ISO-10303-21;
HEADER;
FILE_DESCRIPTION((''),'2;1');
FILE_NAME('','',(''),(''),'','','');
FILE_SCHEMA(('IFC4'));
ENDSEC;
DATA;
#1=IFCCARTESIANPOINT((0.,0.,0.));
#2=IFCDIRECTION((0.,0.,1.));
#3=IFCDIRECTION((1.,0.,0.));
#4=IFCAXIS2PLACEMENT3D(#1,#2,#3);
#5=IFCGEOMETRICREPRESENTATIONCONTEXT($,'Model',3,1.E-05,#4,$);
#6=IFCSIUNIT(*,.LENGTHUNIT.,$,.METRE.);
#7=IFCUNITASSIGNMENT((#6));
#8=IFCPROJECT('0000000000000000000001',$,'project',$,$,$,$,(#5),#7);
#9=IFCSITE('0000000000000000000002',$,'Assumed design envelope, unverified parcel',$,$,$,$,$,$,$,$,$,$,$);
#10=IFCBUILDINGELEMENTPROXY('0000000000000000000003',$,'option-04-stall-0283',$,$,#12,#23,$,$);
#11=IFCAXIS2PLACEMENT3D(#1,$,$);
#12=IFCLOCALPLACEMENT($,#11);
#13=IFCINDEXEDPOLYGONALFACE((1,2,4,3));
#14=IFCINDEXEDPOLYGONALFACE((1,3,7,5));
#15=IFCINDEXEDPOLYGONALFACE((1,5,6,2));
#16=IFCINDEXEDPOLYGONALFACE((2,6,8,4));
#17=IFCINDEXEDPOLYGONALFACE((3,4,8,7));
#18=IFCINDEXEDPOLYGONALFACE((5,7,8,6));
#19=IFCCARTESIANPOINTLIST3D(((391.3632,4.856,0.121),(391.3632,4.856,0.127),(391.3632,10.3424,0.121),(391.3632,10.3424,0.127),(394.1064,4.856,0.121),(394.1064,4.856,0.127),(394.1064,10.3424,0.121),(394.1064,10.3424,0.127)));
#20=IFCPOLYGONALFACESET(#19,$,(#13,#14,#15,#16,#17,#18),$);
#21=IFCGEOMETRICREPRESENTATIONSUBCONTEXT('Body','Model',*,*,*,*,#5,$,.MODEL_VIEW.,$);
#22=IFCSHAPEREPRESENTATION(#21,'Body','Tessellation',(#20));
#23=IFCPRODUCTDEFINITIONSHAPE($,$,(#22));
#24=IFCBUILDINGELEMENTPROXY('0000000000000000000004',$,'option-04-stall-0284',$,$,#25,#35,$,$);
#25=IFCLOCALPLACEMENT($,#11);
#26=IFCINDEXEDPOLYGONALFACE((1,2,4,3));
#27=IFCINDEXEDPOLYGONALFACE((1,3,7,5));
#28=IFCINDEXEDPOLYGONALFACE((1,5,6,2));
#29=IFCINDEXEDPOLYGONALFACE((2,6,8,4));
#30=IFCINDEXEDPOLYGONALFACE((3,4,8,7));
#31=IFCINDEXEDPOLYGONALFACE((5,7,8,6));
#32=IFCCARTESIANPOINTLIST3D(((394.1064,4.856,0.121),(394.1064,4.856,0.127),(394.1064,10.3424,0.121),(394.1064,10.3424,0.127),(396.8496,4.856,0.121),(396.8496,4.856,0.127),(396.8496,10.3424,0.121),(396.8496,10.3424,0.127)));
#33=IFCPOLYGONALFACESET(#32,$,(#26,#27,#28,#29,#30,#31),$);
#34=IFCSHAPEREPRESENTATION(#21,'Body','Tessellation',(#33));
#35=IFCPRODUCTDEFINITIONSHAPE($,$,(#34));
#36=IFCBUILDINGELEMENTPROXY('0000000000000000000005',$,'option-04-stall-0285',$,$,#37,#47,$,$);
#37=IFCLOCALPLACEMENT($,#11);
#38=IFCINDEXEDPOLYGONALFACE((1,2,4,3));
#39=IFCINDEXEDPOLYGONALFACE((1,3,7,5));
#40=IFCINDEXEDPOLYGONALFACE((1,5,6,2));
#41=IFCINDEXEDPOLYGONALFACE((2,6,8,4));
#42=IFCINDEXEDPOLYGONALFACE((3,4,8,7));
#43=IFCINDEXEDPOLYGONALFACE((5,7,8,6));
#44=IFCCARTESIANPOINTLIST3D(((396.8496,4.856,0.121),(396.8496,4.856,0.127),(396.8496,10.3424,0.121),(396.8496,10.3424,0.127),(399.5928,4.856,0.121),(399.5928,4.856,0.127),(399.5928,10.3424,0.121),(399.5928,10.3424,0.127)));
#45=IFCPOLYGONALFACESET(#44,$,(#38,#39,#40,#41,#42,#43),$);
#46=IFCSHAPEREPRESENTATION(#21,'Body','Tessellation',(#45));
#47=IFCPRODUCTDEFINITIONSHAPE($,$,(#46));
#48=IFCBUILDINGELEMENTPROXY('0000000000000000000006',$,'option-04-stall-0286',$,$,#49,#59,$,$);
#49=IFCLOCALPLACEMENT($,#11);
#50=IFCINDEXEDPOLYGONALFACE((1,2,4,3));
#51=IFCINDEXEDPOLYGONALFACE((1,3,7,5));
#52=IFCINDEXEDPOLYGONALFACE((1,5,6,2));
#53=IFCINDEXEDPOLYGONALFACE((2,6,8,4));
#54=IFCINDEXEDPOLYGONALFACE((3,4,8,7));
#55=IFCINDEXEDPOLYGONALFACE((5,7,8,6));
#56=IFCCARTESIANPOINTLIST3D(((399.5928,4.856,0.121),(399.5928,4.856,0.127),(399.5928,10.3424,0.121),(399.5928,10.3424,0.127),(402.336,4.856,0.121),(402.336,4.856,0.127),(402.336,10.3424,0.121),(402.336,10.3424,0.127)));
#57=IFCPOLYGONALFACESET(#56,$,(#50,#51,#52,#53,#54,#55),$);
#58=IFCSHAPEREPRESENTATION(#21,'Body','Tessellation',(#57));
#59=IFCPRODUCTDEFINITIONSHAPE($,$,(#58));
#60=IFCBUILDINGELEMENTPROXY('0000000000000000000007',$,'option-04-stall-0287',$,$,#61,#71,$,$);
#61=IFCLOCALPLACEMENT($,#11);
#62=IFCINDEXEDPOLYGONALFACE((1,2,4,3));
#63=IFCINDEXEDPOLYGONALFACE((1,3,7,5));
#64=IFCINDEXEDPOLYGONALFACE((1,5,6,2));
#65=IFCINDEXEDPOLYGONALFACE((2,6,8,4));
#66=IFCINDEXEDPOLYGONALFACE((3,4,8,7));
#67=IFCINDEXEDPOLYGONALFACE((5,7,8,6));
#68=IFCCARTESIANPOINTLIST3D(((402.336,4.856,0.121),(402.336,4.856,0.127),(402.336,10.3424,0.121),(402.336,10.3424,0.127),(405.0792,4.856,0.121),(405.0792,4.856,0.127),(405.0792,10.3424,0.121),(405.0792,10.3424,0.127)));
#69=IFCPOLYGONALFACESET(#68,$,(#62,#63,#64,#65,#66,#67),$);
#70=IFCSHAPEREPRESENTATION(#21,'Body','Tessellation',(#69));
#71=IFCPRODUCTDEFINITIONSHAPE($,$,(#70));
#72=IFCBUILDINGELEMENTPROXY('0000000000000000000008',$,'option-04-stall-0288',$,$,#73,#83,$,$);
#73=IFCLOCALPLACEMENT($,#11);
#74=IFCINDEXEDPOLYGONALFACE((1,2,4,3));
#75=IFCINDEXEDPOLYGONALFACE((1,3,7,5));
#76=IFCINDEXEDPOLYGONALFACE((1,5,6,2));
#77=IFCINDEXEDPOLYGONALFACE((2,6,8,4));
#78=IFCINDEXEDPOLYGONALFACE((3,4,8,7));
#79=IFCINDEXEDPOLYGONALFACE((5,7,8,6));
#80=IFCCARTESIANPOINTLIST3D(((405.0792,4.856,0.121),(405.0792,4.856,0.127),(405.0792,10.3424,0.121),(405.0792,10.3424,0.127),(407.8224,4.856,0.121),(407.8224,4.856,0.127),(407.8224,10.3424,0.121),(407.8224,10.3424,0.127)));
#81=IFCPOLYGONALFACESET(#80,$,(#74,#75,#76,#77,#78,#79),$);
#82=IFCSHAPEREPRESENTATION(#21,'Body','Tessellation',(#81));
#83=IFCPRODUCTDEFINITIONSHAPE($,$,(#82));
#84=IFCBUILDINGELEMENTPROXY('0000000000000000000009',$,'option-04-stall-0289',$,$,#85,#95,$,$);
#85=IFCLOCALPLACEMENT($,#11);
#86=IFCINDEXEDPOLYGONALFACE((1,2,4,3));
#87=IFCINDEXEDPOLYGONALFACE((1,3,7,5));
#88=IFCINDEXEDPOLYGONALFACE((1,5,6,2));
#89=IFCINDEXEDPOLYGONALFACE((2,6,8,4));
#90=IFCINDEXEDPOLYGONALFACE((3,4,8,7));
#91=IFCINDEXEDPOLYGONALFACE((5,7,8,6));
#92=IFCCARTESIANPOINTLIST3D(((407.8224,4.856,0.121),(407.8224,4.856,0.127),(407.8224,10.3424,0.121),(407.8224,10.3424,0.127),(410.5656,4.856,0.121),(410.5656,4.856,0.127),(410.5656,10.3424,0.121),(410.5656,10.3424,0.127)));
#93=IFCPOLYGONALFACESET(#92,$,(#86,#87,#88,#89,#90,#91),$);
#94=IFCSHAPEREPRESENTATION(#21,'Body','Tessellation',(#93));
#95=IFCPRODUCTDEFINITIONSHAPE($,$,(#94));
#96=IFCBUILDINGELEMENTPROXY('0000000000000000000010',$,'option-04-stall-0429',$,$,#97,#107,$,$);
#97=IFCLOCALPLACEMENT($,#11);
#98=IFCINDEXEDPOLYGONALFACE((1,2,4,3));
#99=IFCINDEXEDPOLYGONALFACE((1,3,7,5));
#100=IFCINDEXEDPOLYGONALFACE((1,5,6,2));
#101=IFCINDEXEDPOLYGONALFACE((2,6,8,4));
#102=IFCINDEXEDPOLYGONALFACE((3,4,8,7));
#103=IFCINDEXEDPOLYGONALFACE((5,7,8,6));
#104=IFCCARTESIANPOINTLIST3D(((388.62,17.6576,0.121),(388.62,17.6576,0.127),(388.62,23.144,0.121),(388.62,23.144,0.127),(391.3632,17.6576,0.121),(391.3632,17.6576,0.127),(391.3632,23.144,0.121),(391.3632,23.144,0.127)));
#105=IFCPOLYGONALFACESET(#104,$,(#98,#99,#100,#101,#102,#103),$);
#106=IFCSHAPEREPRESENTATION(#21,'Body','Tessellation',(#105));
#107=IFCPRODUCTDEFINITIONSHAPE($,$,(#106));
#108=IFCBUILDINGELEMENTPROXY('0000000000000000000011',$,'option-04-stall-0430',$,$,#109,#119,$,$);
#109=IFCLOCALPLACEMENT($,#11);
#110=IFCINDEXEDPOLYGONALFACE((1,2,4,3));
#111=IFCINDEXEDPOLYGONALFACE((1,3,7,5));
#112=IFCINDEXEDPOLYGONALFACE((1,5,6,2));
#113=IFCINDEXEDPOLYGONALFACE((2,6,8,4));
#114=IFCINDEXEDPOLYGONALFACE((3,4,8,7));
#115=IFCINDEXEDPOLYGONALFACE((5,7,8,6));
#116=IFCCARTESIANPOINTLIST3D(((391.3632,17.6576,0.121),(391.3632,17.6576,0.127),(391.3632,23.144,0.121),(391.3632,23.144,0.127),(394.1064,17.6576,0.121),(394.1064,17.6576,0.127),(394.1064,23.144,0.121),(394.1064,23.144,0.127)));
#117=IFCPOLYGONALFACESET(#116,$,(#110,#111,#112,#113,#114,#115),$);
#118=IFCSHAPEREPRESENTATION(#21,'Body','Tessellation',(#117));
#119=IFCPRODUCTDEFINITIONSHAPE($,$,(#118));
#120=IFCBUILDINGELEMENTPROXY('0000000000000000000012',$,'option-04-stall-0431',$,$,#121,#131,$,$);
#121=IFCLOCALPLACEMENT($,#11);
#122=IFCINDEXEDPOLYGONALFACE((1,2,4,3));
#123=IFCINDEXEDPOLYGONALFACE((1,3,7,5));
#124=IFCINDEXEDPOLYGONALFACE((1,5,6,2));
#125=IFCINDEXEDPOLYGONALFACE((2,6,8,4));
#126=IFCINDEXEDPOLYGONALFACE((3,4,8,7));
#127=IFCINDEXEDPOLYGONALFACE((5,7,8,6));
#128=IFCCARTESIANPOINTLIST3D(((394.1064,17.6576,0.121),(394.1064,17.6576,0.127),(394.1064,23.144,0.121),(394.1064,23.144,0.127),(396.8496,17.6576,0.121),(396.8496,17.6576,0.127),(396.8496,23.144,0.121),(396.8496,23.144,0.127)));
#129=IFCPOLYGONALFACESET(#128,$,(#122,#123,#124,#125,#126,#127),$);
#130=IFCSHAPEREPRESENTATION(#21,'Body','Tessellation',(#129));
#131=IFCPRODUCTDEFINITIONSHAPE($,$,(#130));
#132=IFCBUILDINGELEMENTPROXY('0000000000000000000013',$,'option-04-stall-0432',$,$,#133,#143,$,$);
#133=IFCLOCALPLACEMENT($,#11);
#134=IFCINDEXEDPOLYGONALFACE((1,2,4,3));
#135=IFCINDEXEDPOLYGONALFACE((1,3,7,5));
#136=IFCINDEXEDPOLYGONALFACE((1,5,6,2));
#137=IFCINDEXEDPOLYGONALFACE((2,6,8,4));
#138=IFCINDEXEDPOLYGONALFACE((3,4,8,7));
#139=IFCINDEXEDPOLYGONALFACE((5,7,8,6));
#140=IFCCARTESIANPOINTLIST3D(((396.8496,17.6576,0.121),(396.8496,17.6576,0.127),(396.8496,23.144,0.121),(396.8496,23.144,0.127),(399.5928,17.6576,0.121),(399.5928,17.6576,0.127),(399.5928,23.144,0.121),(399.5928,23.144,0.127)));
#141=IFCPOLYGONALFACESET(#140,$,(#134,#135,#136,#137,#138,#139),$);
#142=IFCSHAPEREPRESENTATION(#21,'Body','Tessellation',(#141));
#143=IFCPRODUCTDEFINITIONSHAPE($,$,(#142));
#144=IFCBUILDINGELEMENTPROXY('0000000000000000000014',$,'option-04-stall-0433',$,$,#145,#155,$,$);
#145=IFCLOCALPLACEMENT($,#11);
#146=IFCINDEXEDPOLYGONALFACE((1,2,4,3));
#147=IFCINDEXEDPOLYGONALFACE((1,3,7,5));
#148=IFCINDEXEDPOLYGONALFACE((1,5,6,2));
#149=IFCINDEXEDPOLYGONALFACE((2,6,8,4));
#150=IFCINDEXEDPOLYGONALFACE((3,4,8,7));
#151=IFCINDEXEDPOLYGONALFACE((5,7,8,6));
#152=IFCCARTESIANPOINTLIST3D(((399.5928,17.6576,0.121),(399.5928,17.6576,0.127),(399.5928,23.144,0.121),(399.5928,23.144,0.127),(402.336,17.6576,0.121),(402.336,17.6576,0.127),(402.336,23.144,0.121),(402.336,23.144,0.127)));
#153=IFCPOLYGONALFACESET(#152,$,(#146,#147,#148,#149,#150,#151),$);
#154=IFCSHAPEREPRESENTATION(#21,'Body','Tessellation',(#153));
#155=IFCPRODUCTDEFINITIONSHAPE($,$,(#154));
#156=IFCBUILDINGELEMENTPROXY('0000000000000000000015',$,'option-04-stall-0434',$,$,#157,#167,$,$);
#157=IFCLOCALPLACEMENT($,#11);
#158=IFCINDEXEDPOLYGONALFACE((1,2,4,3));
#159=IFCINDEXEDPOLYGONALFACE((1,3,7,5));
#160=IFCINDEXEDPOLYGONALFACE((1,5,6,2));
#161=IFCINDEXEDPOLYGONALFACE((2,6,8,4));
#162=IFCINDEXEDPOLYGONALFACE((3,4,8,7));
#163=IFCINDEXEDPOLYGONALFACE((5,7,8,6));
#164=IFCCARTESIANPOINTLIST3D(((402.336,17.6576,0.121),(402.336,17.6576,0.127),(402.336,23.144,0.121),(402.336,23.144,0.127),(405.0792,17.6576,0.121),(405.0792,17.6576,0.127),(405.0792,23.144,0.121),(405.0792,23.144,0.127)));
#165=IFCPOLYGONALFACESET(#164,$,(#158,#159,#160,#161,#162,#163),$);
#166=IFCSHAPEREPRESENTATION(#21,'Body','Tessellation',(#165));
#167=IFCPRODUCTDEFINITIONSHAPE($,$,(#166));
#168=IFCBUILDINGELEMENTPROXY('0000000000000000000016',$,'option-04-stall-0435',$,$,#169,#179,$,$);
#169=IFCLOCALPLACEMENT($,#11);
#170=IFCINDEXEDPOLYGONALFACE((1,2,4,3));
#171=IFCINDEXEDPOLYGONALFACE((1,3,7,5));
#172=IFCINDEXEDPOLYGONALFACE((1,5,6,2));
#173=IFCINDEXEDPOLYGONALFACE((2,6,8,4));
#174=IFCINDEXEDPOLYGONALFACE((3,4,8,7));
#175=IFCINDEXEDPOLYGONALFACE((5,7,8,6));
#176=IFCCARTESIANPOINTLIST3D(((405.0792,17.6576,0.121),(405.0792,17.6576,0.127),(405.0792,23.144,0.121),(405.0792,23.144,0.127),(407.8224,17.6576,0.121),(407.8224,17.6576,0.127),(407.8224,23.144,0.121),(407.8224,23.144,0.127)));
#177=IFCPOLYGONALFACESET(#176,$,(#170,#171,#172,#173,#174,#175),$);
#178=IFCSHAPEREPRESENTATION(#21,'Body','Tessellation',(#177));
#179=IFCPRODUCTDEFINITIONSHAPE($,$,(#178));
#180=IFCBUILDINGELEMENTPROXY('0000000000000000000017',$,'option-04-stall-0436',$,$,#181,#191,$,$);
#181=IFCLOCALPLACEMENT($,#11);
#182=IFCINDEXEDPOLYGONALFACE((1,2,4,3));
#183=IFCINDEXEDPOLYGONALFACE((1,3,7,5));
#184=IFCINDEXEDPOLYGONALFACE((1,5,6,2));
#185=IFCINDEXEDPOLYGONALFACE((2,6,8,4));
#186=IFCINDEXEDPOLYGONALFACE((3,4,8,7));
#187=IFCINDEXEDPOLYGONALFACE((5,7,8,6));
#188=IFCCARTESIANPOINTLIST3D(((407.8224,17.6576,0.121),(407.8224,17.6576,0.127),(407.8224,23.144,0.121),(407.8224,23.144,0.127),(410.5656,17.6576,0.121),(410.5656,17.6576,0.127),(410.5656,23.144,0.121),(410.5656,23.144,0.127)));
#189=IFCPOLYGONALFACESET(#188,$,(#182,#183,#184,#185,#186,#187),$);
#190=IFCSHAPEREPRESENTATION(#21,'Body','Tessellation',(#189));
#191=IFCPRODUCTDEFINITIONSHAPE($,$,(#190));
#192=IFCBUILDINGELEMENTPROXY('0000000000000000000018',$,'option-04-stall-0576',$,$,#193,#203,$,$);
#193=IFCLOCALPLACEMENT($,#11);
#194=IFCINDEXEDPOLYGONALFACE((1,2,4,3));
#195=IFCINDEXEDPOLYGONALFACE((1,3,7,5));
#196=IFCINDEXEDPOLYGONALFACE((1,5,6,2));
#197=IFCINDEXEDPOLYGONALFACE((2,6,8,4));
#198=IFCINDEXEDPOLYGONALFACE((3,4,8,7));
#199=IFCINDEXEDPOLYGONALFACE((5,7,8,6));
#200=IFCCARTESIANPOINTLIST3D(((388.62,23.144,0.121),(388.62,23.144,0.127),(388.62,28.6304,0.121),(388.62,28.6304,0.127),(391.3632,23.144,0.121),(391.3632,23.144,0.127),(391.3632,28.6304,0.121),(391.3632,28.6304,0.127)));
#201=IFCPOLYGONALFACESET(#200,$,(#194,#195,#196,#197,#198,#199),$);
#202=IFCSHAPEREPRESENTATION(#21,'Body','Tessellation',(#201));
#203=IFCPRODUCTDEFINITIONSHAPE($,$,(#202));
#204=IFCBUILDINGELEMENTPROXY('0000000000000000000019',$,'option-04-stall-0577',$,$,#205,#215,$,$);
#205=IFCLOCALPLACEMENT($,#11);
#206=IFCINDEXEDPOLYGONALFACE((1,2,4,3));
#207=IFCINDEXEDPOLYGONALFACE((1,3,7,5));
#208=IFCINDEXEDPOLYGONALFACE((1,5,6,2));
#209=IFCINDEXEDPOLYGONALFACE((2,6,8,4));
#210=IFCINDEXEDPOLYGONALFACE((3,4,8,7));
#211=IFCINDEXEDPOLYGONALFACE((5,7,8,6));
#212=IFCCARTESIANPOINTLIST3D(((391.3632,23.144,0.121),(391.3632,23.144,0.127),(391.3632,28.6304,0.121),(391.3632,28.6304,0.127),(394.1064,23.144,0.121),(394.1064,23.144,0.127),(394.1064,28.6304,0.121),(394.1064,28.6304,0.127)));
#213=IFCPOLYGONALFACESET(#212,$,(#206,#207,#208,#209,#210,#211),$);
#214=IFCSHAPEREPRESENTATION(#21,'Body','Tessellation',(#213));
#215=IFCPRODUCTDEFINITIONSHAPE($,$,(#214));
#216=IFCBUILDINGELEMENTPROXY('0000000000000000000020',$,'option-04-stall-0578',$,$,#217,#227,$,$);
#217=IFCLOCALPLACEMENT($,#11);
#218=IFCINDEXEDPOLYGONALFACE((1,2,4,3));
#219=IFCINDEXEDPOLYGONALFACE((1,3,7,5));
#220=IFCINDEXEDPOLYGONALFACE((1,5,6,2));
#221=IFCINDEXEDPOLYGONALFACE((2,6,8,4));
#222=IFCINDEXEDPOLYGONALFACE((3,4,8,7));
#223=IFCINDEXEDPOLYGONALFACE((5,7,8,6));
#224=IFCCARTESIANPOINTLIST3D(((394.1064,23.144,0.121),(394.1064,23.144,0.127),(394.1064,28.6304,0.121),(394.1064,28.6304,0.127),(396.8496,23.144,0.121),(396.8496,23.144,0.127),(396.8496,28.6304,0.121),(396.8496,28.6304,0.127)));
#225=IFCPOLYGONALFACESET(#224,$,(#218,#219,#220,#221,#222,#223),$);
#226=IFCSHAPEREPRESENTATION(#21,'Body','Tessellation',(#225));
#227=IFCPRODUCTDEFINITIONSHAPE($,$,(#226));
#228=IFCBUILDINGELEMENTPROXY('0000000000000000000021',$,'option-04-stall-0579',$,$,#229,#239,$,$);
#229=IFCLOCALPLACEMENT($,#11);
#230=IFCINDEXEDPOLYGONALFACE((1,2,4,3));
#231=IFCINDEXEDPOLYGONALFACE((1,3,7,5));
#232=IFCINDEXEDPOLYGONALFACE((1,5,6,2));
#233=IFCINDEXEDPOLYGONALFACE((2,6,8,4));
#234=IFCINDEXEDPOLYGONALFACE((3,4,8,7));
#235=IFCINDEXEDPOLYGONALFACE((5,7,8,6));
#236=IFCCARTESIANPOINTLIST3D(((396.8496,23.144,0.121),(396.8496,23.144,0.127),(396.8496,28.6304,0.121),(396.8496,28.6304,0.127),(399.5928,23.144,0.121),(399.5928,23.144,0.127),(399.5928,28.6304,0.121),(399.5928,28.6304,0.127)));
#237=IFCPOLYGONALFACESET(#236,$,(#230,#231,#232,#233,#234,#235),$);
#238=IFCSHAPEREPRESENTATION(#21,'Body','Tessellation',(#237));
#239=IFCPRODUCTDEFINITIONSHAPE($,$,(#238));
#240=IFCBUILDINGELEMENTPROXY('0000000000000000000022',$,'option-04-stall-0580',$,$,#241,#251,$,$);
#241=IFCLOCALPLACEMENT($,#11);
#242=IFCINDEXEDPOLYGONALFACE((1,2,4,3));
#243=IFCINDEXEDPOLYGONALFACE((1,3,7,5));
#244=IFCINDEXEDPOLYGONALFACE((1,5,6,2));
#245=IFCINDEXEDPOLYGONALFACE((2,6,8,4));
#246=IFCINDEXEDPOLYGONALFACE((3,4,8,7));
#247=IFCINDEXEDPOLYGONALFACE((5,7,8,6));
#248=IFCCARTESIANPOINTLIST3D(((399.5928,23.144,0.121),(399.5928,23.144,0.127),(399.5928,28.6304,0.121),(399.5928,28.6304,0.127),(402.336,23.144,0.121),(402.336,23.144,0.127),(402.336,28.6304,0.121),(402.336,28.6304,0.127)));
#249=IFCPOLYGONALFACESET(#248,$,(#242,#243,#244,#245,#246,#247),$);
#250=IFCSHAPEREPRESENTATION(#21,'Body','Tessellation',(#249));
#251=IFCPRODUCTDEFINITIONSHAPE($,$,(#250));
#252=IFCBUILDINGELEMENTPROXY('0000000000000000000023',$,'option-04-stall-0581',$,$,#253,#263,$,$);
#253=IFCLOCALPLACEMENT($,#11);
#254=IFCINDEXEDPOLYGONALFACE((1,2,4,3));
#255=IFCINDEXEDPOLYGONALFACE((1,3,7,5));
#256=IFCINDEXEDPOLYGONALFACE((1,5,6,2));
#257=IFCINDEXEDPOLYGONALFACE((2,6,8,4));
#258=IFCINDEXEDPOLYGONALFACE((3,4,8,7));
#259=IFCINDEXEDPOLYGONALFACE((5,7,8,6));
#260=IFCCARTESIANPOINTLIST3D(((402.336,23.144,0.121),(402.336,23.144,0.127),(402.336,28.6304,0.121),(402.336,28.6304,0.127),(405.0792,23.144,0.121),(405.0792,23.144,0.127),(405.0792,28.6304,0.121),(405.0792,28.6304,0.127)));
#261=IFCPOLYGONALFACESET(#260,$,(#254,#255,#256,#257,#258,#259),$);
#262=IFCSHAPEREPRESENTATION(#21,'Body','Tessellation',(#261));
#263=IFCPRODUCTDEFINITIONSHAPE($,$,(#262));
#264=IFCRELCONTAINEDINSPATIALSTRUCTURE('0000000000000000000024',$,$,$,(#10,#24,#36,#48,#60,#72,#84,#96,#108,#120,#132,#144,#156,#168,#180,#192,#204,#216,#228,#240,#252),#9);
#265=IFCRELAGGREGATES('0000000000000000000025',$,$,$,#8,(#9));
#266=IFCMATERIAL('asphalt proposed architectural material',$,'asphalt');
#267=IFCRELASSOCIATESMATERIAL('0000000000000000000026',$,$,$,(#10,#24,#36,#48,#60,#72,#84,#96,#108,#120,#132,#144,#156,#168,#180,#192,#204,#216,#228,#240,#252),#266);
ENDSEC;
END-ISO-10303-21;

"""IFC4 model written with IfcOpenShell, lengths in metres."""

from ifc_helpers import new_model, si_unit, frame, origin_with_axes, place, context, subcontext, project, spatial, rectangle, extrude, material, element, save


model = new_model("IFC4")

# Units and contexts
model_context = context("Model", 3, precision=1e-05, world=origin_with_axes())
body_context = subcontext(model_context, "Body", "Model", "MODEL_VIEW")
ifc_project = project(units=[si_unit("LENGTHUNIT", "METRE")], contexts=[model_context])

# Site
site = spatial("IfcSite", under=ifc_project, Name="Assumed design envelope, unverified parcel")

# Building element proxies
ifc_material = material(Name="asphalt proposed architectural material", Category="asphalt")
for number, where, z_axis, x_axis, name in (
    (1, (392.7348, 7.5992, 0.121), (0.0, 0.0, 1.0), (1.0, 0.0, 0.0), "option-04-stall-0283"),
    (2, (395.478, 7.5992, 0.121), (0.0, 0.0, 1.0), (1.0, 0.0, 0.0), "option-04-stall-0284"),
    (3, (398.2212, 7.5992, 0.121), (0.0, 0.0, 1.0), (1.0, 0.0, 0.0), "option-04-stall-0285"),
    (4, (400.9644, 7.5992, 0.121), (0.0, 0.0, 1.0), (1.0, 0.0, 0.0), "option-04-stall-0286"),
    (5, (403.7076, 7.5992, 0.121), (0.0, 0.0, 1.0), (1.0, 0.0, 0.0), "option-04-stall-0287"),
    (6, (406.4508, 7.5992, 0.121), (0.0, 0.0, 1.0), (1.0, 0.0, 0.0), "option-04-stall-0288"),
    (7, (409.194, 7.5992, 0.121), (0.0, 0.0, 1.0), (1.0, 0.0, 0.0), "option-04-stall-0289"),
):
    element("IfcBuildingElementProxy", number, at=place(None, frame(where, z_axis=z_axis, x_axis=x_axis)), inside=site, material=ifc_material, Name=name, context=body_context, shape_type="SweptSolid", body=[
        extrude(rectangle(XDim=2.7432, YDim=5.4864), origin_with_axes(), (0.0, 0.0, 1.0), 0.006),
    ])
for number, where, z_axis, x_axis, name in (
    (8, (389.9916, 20.4008, 0.121), (0.0, 0.0, 1.0), (1.0, 0.0, 0.0), "option-04-stall-0429"),
    (9, (392.7348, 20.4008, 0.121), (0.0, 0.0, 1.0), (1.0, 0.0, 0.0), "option-04-stall-0430"),
    (10, (395.478, 20.4008, 0.121), (0.0, 0.0, 1.0), (1.0, 0.0, 0.0), "option-04-stall-0431"),
    (11, (398.2212, 20.4008, 0.121), (0.0, 0.0, 1.0), (1.0, 0.0, 0.0), "option-04-stall-0432"),
    (12, (400.9644, 20.4008, 0.121), (0.0, 0.0, 1.0), (1.0, 0.0, 0.0), "option-04-stall-0433"),
    (13, (403.7076, 20.4008, 0.121), (0.0, 0.0, 1.0), (1.0, 0.0, 0.0), "option-04-stall-0434"),
    (14, (406.4508, 20.4008, 0.121), (0.0, 0.0, 1.0), (1.0, 0.0, 0.0), "option-04-stall-0435"),
    (15, (409.194, 20.4008, 0.121), (0.0, 0.0, 1.0), (1.0, 0.0, 0.0), "option-04-stall-0436"),
    (16, (389.9916, 25.8872, 0.121), (0.0, 0.0, 1.0), (1.0, 0.0, 0.0), "option-04-stall-0576"),
    (17, (392.7348, 25.8872, 0.121), (0.0, 0.0, 1.0), (1.0, 0.0, 0.0), "option-04-stall-0577"),
    (18, (395.478, 25.8872, 0.121), (0.0, 0.0, 1.0), (1.0, 0.0, 0.0), "option-04-stall-0578"),
    (19, (398.2212, 25.8872, 0.121), (0.0, 0.0, 1.0), (1.0, 0.0, 0.0), "option-04-stall-0579"),
    (20, (400.9644, 25.8872, 0.121), (0.0, 0.0, 1.0), (1.0, 0.0, 0.0), "option-04-stall-0580"),
    (21, (403.7076, 25.8872, 0.121), (0.0, 0.0, 1.0), (1.0, 0.0, 0.0), "option-04-stall-0581"),
):
    element("IfcBuildingElementProxy", number, at=place(None, frame(where, z_axis=z_axis, x_axis=x_axis)), inside=site, material=ifc_material, Name=name, context=body_context, shape_type="SweptSolid", body=[
        extrude(rectangle(XDim=2.7432, YDim=5.4864), origin_with_axes(), (0.0, 0.0, 1.0), 0.006),
    ])

save(model, "model.ifc")
